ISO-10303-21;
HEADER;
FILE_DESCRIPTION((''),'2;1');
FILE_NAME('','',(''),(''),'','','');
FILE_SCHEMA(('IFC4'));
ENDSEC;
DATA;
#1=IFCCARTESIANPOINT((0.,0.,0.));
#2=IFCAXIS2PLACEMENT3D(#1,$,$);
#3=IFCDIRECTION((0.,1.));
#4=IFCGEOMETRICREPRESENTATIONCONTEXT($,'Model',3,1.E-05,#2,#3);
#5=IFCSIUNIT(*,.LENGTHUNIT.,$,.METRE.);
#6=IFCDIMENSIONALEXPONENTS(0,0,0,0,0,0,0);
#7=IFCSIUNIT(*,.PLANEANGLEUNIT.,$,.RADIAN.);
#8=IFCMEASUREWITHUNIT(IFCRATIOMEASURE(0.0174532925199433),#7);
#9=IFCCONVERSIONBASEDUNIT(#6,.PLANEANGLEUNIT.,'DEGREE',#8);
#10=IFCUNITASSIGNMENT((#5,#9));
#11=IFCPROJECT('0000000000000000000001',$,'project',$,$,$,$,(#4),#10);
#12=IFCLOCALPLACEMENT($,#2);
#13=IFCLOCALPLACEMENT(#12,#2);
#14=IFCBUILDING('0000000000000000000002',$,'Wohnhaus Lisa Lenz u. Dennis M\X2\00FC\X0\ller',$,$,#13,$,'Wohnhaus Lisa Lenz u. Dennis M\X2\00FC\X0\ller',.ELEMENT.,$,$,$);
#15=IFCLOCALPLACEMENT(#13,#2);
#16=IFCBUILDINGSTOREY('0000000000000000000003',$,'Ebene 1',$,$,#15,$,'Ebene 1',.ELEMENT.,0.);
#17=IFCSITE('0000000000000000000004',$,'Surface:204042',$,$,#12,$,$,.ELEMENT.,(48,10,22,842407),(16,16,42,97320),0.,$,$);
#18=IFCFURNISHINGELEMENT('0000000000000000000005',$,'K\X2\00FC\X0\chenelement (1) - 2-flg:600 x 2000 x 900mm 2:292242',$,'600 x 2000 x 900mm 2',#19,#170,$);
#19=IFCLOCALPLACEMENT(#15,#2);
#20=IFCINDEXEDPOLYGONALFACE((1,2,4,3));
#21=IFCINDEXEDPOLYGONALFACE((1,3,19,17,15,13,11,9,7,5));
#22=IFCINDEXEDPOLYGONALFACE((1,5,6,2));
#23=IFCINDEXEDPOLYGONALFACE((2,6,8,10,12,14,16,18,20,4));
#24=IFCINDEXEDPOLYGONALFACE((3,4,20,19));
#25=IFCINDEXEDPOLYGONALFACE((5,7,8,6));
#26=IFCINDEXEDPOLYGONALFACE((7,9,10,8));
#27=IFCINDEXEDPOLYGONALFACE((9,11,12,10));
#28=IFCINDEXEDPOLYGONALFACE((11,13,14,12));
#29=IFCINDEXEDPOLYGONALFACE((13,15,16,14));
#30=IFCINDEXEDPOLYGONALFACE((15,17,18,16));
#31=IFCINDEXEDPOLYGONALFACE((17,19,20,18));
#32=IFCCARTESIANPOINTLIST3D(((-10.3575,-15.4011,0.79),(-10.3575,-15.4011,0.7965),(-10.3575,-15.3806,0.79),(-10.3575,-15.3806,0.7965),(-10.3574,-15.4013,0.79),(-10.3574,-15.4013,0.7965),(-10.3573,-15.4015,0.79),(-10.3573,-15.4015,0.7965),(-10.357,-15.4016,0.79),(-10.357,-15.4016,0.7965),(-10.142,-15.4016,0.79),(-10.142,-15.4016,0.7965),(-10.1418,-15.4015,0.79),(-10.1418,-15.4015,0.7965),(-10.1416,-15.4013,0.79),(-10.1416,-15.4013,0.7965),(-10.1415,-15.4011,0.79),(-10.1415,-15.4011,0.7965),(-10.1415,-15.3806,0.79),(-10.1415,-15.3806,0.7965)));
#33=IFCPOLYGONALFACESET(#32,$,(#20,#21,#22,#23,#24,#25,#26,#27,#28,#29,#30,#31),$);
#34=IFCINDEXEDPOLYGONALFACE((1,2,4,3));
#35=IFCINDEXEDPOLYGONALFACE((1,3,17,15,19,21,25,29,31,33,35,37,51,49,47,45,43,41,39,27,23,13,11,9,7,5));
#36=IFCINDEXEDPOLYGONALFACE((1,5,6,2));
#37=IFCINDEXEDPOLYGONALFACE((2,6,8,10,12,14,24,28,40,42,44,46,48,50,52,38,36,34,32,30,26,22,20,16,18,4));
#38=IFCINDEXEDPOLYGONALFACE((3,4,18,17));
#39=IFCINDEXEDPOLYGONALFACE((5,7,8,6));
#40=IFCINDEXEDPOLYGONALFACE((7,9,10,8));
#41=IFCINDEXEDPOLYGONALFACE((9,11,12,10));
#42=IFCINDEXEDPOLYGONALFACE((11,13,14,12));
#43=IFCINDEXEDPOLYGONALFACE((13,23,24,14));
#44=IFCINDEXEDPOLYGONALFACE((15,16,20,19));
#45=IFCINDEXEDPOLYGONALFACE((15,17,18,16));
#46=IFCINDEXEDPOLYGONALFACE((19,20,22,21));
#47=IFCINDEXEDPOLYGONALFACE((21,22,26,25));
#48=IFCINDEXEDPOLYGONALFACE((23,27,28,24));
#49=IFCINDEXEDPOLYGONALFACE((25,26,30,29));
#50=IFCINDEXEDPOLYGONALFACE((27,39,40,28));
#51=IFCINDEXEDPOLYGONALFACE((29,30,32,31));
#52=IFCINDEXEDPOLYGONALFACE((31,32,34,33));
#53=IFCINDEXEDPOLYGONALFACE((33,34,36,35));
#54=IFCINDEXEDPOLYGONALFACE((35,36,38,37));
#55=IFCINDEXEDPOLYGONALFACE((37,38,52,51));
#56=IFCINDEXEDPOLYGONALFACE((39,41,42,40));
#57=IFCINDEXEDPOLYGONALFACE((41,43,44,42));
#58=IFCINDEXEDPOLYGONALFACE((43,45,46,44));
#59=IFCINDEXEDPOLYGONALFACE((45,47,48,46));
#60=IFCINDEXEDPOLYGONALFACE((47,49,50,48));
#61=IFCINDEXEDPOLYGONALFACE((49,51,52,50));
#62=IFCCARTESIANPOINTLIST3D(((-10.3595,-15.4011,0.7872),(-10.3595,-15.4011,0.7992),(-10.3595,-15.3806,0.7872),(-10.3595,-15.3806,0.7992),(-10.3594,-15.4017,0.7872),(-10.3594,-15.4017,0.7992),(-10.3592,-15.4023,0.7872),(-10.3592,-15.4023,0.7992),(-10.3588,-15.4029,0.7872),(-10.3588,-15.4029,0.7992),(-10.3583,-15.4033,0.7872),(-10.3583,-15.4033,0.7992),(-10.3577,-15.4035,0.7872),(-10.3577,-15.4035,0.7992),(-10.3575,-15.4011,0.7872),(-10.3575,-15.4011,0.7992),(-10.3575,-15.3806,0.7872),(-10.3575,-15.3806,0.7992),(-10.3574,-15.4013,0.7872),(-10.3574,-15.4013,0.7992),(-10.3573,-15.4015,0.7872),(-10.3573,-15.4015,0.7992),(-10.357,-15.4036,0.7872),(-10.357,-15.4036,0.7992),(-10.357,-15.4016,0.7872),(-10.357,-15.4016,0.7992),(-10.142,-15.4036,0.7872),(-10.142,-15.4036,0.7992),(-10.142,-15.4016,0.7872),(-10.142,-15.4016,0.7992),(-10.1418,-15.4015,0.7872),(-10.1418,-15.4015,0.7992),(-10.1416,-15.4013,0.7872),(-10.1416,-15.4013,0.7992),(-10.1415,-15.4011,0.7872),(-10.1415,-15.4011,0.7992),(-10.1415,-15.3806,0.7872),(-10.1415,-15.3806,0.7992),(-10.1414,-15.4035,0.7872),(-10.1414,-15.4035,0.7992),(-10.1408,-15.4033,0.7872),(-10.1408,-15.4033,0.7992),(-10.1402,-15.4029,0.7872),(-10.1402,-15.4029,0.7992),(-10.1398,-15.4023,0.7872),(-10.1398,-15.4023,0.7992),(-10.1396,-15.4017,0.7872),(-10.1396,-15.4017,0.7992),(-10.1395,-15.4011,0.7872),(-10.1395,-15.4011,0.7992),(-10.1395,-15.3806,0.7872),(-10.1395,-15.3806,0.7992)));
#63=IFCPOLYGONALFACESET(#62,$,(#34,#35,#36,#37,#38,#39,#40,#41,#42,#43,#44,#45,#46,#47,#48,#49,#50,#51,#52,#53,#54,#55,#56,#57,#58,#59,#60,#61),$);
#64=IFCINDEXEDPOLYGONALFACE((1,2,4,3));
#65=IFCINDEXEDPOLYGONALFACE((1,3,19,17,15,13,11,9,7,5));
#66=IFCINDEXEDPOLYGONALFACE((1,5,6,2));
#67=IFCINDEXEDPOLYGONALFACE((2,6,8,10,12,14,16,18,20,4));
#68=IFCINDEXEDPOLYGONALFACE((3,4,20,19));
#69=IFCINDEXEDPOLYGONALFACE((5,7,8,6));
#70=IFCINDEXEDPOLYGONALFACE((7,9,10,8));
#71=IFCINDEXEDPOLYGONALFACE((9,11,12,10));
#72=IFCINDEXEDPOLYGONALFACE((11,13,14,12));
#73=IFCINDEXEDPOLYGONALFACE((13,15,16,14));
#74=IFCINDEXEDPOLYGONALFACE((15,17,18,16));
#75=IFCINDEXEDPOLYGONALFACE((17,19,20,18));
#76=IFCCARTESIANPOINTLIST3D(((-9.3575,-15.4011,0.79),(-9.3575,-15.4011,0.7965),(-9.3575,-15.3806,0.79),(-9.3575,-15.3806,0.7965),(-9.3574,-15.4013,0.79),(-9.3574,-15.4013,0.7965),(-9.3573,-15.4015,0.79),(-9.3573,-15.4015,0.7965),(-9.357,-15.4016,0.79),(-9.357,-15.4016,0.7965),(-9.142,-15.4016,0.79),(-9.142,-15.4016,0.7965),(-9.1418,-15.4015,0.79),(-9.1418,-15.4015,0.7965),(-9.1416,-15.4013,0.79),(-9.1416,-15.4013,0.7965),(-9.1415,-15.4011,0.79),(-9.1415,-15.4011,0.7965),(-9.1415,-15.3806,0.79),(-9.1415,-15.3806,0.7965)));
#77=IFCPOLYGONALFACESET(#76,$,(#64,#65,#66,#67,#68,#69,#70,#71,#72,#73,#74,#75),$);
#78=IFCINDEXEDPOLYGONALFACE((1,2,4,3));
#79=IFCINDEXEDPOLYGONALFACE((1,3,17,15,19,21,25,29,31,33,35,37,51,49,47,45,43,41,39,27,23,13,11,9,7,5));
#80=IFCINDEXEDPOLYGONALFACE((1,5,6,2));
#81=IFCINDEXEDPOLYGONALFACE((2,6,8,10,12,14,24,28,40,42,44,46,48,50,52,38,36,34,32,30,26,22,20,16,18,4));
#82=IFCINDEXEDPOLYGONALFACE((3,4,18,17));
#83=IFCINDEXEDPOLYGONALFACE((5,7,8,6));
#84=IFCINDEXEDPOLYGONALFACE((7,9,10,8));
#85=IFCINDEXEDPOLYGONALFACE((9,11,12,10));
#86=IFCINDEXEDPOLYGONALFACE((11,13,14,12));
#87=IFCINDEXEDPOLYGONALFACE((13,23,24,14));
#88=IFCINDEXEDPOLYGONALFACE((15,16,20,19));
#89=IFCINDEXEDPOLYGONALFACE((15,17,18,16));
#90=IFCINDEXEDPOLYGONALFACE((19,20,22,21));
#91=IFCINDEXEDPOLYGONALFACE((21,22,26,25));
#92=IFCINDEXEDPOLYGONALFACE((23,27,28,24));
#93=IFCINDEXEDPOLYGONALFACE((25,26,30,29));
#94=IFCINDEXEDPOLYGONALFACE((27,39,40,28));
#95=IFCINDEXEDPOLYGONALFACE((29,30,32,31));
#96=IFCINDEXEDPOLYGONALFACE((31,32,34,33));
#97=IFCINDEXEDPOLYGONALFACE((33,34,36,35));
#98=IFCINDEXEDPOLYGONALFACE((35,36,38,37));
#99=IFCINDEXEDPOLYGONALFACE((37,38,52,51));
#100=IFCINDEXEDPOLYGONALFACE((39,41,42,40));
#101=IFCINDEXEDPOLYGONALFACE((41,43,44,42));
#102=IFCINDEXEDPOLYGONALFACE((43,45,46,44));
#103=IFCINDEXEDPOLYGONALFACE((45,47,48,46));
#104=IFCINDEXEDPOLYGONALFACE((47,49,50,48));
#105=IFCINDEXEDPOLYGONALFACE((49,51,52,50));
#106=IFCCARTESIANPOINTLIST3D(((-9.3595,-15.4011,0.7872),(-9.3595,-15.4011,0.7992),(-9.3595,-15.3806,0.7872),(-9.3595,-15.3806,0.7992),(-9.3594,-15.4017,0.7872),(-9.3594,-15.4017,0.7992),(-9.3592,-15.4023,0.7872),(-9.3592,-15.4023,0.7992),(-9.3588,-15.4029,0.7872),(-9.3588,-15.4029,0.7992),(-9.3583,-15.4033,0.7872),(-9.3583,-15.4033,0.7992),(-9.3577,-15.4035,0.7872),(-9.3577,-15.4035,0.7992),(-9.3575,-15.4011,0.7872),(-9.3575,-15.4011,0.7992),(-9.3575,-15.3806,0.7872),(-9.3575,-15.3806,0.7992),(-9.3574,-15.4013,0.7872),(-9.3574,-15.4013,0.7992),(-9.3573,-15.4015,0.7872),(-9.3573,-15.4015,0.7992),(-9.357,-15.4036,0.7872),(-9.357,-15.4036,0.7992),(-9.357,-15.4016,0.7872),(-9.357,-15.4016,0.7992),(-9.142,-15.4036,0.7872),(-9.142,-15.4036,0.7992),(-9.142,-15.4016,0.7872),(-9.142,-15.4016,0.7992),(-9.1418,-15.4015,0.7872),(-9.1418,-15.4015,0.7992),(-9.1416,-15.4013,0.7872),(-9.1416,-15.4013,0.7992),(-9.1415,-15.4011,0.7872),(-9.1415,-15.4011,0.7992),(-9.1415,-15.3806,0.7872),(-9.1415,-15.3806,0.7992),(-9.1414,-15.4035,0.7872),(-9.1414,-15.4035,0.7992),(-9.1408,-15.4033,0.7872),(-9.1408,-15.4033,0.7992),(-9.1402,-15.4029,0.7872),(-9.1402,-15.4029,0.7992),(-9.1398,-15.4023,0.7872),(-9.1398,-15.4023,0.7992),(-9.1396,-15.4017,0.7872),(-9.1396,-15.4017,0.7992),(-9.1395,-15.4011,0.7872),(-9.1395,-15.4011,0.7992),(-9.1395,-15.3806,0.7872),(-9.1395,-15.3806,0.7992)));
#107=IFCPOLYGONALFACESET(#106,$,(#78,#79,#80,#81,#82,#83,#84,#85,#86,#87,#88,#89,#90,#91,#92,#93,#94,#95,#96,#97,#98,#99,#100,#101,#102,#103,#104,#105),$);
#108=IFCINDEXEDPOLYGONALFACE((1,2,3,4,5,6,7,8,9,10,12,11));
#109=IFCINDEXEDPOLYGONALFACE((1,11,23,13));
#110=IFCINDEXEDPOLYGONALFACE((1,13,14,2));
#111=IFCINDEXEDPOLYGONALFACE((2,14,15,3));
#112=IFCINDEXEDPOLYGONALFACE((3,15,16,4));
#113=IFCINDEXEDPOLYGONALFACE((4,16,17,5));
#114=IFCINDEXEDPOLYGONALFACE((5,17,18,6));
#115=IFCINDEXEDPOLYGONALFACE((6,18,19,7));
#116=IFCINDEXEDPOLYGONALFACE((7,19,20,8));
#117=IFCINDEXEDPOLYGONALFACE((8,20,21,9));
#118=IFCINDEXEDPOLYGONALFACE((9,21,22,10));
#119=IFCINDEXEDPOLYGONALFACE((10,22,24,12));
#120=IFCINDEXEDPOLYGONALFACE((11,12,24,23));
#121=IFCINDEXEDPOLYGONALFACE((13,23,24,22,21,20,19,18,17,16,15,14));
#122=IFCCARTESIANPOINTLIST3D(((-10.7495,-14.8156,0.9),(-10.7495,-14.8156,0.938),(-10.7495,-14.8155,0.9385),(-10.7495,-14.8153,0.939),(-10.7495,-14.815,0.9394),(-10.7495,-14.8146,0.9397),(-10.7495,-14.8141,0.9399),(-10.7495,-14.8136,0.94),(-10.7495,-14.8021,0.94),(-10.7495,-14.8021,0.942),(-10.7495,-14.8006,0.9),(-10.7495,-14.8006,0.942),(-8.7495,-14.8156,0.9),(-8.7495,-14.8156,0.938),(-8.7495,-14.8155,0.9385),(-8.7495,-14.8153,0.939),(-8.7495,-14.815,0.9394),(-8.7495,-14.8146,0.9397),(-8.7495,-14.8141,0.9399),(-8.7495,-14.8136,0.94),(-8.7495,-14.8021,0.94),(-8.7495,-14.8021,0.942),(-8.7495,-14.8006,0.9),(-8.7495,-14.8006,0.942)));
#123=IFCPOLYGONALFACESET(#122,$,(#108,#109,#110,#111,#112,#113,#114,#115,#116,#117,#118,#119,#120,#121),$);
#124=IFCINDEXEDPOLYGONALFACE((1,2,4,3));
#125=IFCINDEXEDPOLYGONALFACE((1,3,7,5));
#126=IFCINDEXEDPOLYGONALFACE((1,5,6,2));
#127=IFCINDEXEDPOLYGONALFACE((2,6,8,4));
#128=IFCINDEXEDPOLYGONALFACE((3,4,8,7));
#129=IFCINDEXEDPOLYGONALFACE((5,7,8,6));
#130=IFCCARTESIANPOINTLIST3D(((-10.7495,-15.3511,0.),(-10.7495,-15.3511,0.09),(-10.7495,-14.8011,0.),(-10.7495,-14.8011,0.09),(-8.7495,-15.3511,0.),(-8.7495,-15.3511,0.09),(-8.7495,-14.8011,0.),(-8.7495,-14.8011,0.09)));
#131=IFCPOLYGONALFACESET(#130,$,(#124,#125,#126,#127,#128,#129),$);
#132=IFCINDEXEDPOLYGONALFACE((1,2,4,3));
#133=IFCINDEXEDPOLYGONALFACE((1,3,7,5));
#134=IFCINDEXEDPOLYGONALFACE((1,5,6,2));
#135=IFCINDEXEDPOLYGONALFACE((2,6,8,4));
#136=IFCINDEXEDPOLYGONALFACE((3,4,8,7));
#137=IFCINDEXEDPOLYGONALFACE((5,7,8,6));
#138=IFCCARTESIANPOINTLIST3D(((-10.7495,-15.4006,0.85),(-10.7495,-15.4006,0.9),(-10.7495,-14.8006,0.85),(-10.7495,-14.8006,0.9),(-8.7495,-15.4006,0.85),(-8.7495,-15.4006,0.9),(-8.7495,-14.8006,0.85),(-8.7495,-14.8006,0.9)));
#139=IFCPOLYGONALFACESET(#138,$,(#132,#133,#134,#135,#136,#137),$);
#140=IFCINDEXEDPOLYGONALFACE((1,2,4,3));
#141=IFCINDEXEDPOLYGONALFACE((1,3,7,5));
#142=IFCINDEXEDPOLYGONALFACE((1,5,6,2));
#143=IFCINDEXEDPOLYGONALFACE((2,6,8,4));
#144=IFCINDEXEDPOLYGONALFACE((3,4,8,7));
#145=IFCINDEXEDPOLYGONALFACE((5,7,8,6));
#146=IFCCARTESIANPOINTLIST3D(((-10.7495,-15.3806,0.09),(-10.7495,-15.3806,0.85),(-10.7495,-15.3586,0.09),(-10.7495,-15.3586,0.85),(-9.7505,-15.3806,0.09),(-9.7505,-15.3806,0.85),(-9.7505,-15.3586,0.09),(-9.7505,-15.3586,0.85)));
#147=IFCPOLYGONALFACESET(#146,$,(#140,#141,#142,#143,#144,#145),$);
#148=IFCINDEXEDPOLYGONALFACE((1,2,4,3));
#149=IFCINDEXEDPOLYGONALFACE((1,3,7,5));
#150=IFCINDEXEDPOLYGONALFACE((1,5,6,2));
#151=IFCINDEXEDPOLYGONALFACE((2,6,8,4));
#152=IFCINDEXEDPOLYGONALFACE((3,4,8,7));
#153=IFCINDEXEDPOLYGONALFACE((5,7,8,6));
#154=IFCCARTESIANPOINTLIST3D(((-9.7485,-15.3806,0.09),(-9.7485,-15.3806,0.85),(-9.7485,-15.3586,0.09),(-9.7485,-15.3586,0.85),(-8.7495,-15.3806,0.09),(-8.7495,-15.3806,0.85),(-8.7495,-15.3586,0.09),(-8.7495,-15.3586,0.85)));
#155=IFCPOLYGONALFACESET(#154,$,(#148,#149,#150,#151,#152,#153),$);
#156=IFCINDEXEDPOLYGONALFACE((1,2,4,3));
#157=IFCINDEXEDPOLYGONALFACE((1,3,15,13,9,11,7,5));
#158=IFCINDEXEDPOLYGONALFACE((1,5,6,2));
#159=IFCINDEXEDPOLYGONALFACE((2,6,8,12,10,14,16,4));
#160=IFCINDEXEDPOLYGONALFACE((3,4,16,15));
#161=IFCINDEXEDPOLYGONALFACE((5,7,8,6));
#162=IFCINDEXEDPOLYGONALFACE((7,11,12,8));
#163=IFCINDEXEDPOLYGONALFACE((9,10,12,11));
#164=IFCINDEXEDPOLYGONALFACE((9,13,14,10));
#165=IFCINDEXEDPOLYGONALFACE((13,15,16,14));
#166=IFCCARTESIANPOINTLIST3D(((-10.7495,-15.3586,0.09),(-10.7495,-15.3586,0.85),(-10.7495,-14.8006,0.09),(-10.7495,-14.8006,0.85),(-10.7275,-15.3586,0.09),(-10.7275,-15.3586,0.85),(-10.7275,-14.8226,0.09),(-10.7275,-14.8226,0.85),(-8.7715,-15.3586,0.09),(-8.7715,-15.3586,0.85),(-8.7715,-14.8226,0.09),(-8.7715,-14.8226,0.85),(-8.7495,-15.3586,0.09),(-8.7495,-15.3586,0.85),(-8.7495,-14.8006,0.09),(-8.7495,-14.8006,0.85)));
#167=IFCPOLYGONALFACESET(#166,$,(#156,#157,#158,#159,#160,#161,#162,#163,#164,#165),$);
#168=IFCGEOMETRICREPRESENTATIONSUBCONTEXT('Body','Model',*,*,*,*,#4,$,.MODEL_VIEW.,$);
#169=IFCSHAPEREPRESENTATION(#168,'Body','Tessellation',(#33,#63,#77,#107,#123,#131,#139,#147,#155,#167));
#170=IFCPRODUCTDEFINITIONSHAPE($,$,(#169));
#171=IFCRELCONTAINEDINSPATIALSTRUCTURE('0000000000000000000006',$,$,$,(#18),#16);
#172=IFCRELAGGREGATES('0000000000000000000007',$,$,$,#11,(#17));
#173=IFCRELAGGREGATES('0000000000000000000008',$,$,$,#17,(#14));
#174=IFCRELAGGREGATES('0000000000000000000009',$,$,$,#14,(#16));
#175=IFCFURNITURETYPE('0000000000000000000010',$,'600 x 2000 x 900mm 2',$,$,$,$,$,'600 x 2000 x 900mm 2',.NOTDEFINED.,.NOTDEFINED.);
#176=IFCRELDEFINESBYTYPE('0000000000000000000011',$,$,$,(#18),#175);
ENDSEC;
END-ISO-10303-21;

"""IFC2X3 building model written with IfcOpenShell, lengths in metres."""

from ifc_helpers import new_model, entity, si_unit, converted_unit, direction, frame, frame_2d, origin, origin_2d_with_axis, place, context, subcontext, project, spatial, polyline, circle_curve, parameter, trimmed, segment, composite_curve, rectangle, outline, extrude, source, transform, mapped, type_object, type_shapes, element, save


model = new_model("IFC2X3")

# Units and contexts
model_context = context("Model", 3, precision=1e-05, world=origin(), true_north=direction((0.0, 1.0)))
body_context = subcontext(model_context, "Body", "Model", "MODEL_VIEW")
ifc_project = project(units=[si_unit("LENGTHUNIT", "METRE"), converted_unit("PLANEANGLEUNIT", "DEGREE", entity("IfcRatioMeasure", 0.0174532925199433), si_unit("PLANEANGLEUNIT", "RADIAN"), dimensions=[0, 0, 0, 0, 0, 0, 0])], contexts=[model_context])

# Site, building, storey
site_placement = place(None, origin())
site = spatial("IfcSite", under=ifc_project, at=site_placement, Name="Surface:204042", CompositionType="ELEMENT", RefLatitude=(48, 10, 22, 842407), RefLongitude=(16, 16, 42, 97320), RefElevation=0.0)
building_placement = place(site_placement, origin())
building = spatial("IfcBuilding", under=site, at=building_placement, Name="Wohnhaus Lisa Lenz u. Dennis Müller", LongName="Wohnhaus Lisa Lenz u. Dennis Müller", CompositionType="ELEMENT")
storey_placement = place(building_placement, origin())
storey = spatial("IfcBuildingStorey", under=building, at=storey_placement, Name="Ebene 1", LongName="Ebene 1", CompositionType="ELEMENT", Elevation=0.0)

# Furnishing element
furniture_type_1 = type_object("IfcFurnitureType", Name="600 x 2000 x 900mm 2", ElementType="600 x 2000 x 900mm 2")
shared_shape_1 = source(origin(), body_context, "Body", "SweptSolid", [
    extrude(outline(composite_curve([segment(polyline([(-0.108, -0.0138), (0.108, -0.0138)]), True, "CONTINUOUS"), segment(polyline([(0.108, -0.0138), (0.108, 0.0067)]), True, "CONTINUOUS"), segment(trimmed(circle_curve(frame_2d((0.1075, 0.0067), x_axis=(0.0, 1.0)), 0.0005), [parameter(270.0)], [parameter(360.0)], True, "PARAMETER"), True, "CONTINUOUS"), segment(polyline([(0.1075, 0.0072), (-0.1075, 0.0072)]), True, "CONTINUOUS"), segment(trimmed(circle_curve(frame_2d((-0.1075, 0.0067), x_axis=(-1.0, 0.0)), 0.0005), [parameter(270.0)], [parameter(0.0)], True, "PARAMETER"), True, "CONTINUOUS"), segment(polyline([(-0.108, 0.0067), (-0.108, -0.0138)]), True, "CONTINUOUS")], self_intersect=False)), frame((0.5447, 0.5938, 0.79)), (0.0, 0.0, 1.0), 0.0065),
    extrude(outline(composite_curve([segment(polyline([(-0.11, -0.0142), (-0.108, -0.0142)]), True, "CONTINUOUS"), segment(polyline([(-0.108, -0.0142), (-0.108, 0.0063)]), True, "CONTINUOUS"), segment(trimmed(circle_curve(frame_2d((-0.1075, 0.0063), x_axis=(-1.0, 0.0)), 0.0005), [parameter(270.0)], [parameter(0.0)], True, "PARAMETER"), False, "CONTINUOUS"), segment(polyline([(-0.1075, 0.0068), (0.1075, 0.0068)]), True, "CONTINUOUS"), segment(trimmed(circle_curve(frame_2d((0.1075, 0.0063), x_axis=(0.0, 1.0)), 0.0005), [parameter(270.0)], [parameter(0.0)], True, "PARAMETER"), False, "CONTINUOUS"), segment(polyline([(0.108, 0.0063), (0.108, -0.0142)]), True, "CONTINUOUS"), segment(polyline([(0.108, -0.0142), (0.11, -0.0142)]), True, "CONTINUOUS"), segment(polyline([(0.11, -0.0142), (0.11, 0.0063)]), True, "CONTINUOUS"), segment(trimmed(circle_curve(frame_2d((0.1075, 0.0063), x_axis=(0.0, 1.0)), 0.0025), [parameter(270.0)], [parameter(0.0)], True, "PARAMETER"), True, "CONTINUOUS"), segment(polyline([(0.1075, 0.0088), (-0.1075, 0.0088)]), True, "CONTINUOUS"), segment(trimmed(circle_curve(frame_2d((-0.1075, 0.0063), x_axis=(-1.0, 0.0)), 0.0025), [parameter(270.0)], [parameter(0.0)], True, "PARAMETER"), True, "CONTINUOUS"), segment(polyline([(-0.11, 0.0063), (-0.11, -0.0142)]), True, "CONTINUOUS")], self_intersect=False)), frame((0.5447, 0.5942, 0.7872)), (0.0, 0.0, 1.0), 0.012),
    extrude(outline(composite_curve([segment(polyline([(-0.108, -0.0138), (0.108, -0.0138)]), True, "CONTINUOUS"), segment(polyline([(0.108, -0.0138), (0.108, 0.0067)]), True, "CONTINUOUS"), segment(trimmed(circle_curve(frame_2d((0.1075, 0.0067), x_axis=(0.0, 1.0)), 0.0005), [parameter(270.0)], [parameter(360.0)], True, "PARAMETER"), True, "CONTINUOUS"), segment(polyline([(0.1075, 0.0072), (-0.1075, 0.0072)]), True, "CONTINUOUS"), segment(trimmed(circle_curve(frame_2d((-0.1075, 0.0067), x_axis=(-1.0, 0.0)), 0.0005), [parameter(270.0)], [parameter(0.0)], True, "PARAMETER"), True, "CONTINUOUS"), segment(polyline([(-0.108, 0.0067), (-0.108, -0.0138)]), True, "CONTINUOUS")], self_intersect=False)), frame((-0.4553, 0.5938, 0.79)), (0.0, 0.0, 1.0), 0.0065),
    extrude(outline(composite_curve([segment(polyline([(-0.11, -0.0142), (-0.108, -0.0142)]), True, "CONTINUOUS"), segment(polyline([(-0.108, -0.0142), (-0.108, 0.0063)]), True, "CONTINUOUS"), segment(trimmed(circle_curve(frame_2d((-0.1075, 0.0063), x_axis=(-1.0, 0.0)), 0.0005), [parameter(270.0)], [parameter(0.0)], True, "PARAMETER"), False, "CONTINUOUS"), segment(polyline([(-0.1075, 0.0068), (0.1075, 0.0068)]), True, "CONTINUOUS"), segment(trimmed(circle_curve(frame_2d((0.1075, 0.0063), x_axis=(0.0, 1.0)), 0.0005), [parameter(270.0)], [parameter(0.0)], True, "PARAMETER"), False, "CONTINUOUS"), segment(polyline([(0.108, 0.0063), (0.108, -0.0142)]), True, "CONTINUOUS"), segment(polyline([(0.108, -0.0142), (0.11, -0.0142)]), True, "CONTINUOUS"), segment(polyline([(0.11, -0.0142), (0.11, 0.0063)]), True, "CONTINUOUS"), segment(trimmed(circle_curve(frame_2d((0.1075, 0.0063), x_axis=(0.0, 1.0)), 0.0025), [parameter(270.0)], [parameter(0.0)], True, "PARAMETER"), True, "CONTINUOUS"), segment(polyline([(0.1075, 0.0088), (-0.1075, 0.0088)]), True, "CONTINUOUS"), segment(trimmed(circle_curve(frame_2d((-0.1075, 0.0063), x_axis=(-1.0, 0.0)), 0.0025), [parameter(270.0)], [parameter(0.0)], True, "PARAMETER"), True, "CONTINUOUS"), segment(polyline([(-0.11, 0.0063), (-0.11, -0.0142)]), True, "CONTINUOUS")], self_intersect=False)), frame((-0.4553, 0.5942, 0.7872)), (0.0, 0.0, 1.0), 0.012),
    extrude(outline(composite_curve([segment(polyline([(-0.0131, -0.0066), (0.0289, -0.0066)]), True, "CONTINUOUS"), segment(polyline([(0.0289, -0.0066), (0.0289, 0.0084)]), True, "CONTINUOUS"), segment(polyline([(0.0289, 0.0084), (-0.0091, 0.0084)]), True, "CONTINUOUS"), segment(trimmed(circle_curve(frame_2d((-0.0091, 0.0064), x_axis=(0.0, 1.0)), 0.002), [parameter(0.0)], [parameter(90.0)], True, "PARAMETER"), True, "CONTINUOUS"), segment(polyline([(-0.0111, 0.0064), (-0.0111, -0.0051)]), True, "CONTINUOUS"), segment(polyline([(-0.0111, -0.0051), (-0.0131, -0.0051)]), True, "CONTINUOUS"), segment(polyline([(-0.0131, -0.0051), (-0.0131, -0.0066)]), True, "CONTINUOUS")], self_intersect=False)), frame((-0.9553, 0.0066, 0.9289), z_axis=(1.0, 0.0, 0.0), x_axis=(0.0, 0.0, -1.0)), (0.0, 0.0, 1.0), 2.0),
    extrude(rectangle(XDim=0.55, YDim=2.0, at=origin_2d_with_axis()), frame((0.0447, 0.2755, 0.0), z_axis=(0.0, 0.0, 1.0), x_axis=(0.0, 1.0, 0.0)), (0.0, 0.0, 1.0), 0.09),
    extrude(rectangle(XDim=0.6, YDim=2.0, at=origin_2d_with_axis()), frame((0.0447, 0.3, 0.85), z_axis=(0.0, 0.0, 1.0), x_axis=(0.0, 1.0, 0.0)), (0.0, 0.0, 1.0), 0.05),
    extrude(rectangle(XDim=0.022, YDim=0.999, at=frame_2d((0.0, 0.0), x_axis=(1.0, 0.0))), frame((0.5452, 0.569, 0.09), z_axis=(0.0, 0.0, 1.0), x_axis=(0.0, -1.0, 0.0)), (0.0, 0.0, 1.0), 0.76),
    extrude(rectangle(XDim=0.999, YDim=0.022, at=frame_2d((0.0, 0.0), x_axis=(1.0, 0.0))), frame((-0.4558, 0.569, 0.09), z_axis=(0.0, 0.0, 1.0), x_axis=(-1.0, 0.0, 0.0)), (0.0, 0.0, 1.0), 0.76),
    extrude(outline(polyline([(-0.2845, -1.0), (0.2735, -1.0), (0.2735, -0.978), (-0.2625, -0.978), (-0.2625, 0.978), (0.2735, 0.978), (0.2735, 1.0), (-0.2845, 1.0), (-0.2845, -1.0)])), frame((0.0447, 0.2845, 0.09), z_axis=(0.0, 0.0, 1.0), x_axis=(0.0, 1.0, 0.0)), (0.0, 0.0, 1.0), 0.76),
])
type_shapes(furniture_type_1, [shared_shape_1])
furnishing_1_placement = place(storey_placement, frame((-9.7048, -14.8006, 0.0), z_axis=(0.0, 0.0, 1.0), x_axis=(-1.0, 0.0, 0.0)))
element("IfcFurnishingElement", 1, at=furnishing_1_placement, inside=storey, type_object=furniture_type_1, Name="Küchenelement (1) - 2-flg:600 x 2000 x 900mm 2:292242", ObjectType="600 x 2000 x 900mm 2", context=body_context, shape_type="MappedRepresentation", body=[
    mapped(shared_shape_1, transform((0.0, 0.0, 0.0), scale=1.0)),
])

save(model, "model.ifc")
